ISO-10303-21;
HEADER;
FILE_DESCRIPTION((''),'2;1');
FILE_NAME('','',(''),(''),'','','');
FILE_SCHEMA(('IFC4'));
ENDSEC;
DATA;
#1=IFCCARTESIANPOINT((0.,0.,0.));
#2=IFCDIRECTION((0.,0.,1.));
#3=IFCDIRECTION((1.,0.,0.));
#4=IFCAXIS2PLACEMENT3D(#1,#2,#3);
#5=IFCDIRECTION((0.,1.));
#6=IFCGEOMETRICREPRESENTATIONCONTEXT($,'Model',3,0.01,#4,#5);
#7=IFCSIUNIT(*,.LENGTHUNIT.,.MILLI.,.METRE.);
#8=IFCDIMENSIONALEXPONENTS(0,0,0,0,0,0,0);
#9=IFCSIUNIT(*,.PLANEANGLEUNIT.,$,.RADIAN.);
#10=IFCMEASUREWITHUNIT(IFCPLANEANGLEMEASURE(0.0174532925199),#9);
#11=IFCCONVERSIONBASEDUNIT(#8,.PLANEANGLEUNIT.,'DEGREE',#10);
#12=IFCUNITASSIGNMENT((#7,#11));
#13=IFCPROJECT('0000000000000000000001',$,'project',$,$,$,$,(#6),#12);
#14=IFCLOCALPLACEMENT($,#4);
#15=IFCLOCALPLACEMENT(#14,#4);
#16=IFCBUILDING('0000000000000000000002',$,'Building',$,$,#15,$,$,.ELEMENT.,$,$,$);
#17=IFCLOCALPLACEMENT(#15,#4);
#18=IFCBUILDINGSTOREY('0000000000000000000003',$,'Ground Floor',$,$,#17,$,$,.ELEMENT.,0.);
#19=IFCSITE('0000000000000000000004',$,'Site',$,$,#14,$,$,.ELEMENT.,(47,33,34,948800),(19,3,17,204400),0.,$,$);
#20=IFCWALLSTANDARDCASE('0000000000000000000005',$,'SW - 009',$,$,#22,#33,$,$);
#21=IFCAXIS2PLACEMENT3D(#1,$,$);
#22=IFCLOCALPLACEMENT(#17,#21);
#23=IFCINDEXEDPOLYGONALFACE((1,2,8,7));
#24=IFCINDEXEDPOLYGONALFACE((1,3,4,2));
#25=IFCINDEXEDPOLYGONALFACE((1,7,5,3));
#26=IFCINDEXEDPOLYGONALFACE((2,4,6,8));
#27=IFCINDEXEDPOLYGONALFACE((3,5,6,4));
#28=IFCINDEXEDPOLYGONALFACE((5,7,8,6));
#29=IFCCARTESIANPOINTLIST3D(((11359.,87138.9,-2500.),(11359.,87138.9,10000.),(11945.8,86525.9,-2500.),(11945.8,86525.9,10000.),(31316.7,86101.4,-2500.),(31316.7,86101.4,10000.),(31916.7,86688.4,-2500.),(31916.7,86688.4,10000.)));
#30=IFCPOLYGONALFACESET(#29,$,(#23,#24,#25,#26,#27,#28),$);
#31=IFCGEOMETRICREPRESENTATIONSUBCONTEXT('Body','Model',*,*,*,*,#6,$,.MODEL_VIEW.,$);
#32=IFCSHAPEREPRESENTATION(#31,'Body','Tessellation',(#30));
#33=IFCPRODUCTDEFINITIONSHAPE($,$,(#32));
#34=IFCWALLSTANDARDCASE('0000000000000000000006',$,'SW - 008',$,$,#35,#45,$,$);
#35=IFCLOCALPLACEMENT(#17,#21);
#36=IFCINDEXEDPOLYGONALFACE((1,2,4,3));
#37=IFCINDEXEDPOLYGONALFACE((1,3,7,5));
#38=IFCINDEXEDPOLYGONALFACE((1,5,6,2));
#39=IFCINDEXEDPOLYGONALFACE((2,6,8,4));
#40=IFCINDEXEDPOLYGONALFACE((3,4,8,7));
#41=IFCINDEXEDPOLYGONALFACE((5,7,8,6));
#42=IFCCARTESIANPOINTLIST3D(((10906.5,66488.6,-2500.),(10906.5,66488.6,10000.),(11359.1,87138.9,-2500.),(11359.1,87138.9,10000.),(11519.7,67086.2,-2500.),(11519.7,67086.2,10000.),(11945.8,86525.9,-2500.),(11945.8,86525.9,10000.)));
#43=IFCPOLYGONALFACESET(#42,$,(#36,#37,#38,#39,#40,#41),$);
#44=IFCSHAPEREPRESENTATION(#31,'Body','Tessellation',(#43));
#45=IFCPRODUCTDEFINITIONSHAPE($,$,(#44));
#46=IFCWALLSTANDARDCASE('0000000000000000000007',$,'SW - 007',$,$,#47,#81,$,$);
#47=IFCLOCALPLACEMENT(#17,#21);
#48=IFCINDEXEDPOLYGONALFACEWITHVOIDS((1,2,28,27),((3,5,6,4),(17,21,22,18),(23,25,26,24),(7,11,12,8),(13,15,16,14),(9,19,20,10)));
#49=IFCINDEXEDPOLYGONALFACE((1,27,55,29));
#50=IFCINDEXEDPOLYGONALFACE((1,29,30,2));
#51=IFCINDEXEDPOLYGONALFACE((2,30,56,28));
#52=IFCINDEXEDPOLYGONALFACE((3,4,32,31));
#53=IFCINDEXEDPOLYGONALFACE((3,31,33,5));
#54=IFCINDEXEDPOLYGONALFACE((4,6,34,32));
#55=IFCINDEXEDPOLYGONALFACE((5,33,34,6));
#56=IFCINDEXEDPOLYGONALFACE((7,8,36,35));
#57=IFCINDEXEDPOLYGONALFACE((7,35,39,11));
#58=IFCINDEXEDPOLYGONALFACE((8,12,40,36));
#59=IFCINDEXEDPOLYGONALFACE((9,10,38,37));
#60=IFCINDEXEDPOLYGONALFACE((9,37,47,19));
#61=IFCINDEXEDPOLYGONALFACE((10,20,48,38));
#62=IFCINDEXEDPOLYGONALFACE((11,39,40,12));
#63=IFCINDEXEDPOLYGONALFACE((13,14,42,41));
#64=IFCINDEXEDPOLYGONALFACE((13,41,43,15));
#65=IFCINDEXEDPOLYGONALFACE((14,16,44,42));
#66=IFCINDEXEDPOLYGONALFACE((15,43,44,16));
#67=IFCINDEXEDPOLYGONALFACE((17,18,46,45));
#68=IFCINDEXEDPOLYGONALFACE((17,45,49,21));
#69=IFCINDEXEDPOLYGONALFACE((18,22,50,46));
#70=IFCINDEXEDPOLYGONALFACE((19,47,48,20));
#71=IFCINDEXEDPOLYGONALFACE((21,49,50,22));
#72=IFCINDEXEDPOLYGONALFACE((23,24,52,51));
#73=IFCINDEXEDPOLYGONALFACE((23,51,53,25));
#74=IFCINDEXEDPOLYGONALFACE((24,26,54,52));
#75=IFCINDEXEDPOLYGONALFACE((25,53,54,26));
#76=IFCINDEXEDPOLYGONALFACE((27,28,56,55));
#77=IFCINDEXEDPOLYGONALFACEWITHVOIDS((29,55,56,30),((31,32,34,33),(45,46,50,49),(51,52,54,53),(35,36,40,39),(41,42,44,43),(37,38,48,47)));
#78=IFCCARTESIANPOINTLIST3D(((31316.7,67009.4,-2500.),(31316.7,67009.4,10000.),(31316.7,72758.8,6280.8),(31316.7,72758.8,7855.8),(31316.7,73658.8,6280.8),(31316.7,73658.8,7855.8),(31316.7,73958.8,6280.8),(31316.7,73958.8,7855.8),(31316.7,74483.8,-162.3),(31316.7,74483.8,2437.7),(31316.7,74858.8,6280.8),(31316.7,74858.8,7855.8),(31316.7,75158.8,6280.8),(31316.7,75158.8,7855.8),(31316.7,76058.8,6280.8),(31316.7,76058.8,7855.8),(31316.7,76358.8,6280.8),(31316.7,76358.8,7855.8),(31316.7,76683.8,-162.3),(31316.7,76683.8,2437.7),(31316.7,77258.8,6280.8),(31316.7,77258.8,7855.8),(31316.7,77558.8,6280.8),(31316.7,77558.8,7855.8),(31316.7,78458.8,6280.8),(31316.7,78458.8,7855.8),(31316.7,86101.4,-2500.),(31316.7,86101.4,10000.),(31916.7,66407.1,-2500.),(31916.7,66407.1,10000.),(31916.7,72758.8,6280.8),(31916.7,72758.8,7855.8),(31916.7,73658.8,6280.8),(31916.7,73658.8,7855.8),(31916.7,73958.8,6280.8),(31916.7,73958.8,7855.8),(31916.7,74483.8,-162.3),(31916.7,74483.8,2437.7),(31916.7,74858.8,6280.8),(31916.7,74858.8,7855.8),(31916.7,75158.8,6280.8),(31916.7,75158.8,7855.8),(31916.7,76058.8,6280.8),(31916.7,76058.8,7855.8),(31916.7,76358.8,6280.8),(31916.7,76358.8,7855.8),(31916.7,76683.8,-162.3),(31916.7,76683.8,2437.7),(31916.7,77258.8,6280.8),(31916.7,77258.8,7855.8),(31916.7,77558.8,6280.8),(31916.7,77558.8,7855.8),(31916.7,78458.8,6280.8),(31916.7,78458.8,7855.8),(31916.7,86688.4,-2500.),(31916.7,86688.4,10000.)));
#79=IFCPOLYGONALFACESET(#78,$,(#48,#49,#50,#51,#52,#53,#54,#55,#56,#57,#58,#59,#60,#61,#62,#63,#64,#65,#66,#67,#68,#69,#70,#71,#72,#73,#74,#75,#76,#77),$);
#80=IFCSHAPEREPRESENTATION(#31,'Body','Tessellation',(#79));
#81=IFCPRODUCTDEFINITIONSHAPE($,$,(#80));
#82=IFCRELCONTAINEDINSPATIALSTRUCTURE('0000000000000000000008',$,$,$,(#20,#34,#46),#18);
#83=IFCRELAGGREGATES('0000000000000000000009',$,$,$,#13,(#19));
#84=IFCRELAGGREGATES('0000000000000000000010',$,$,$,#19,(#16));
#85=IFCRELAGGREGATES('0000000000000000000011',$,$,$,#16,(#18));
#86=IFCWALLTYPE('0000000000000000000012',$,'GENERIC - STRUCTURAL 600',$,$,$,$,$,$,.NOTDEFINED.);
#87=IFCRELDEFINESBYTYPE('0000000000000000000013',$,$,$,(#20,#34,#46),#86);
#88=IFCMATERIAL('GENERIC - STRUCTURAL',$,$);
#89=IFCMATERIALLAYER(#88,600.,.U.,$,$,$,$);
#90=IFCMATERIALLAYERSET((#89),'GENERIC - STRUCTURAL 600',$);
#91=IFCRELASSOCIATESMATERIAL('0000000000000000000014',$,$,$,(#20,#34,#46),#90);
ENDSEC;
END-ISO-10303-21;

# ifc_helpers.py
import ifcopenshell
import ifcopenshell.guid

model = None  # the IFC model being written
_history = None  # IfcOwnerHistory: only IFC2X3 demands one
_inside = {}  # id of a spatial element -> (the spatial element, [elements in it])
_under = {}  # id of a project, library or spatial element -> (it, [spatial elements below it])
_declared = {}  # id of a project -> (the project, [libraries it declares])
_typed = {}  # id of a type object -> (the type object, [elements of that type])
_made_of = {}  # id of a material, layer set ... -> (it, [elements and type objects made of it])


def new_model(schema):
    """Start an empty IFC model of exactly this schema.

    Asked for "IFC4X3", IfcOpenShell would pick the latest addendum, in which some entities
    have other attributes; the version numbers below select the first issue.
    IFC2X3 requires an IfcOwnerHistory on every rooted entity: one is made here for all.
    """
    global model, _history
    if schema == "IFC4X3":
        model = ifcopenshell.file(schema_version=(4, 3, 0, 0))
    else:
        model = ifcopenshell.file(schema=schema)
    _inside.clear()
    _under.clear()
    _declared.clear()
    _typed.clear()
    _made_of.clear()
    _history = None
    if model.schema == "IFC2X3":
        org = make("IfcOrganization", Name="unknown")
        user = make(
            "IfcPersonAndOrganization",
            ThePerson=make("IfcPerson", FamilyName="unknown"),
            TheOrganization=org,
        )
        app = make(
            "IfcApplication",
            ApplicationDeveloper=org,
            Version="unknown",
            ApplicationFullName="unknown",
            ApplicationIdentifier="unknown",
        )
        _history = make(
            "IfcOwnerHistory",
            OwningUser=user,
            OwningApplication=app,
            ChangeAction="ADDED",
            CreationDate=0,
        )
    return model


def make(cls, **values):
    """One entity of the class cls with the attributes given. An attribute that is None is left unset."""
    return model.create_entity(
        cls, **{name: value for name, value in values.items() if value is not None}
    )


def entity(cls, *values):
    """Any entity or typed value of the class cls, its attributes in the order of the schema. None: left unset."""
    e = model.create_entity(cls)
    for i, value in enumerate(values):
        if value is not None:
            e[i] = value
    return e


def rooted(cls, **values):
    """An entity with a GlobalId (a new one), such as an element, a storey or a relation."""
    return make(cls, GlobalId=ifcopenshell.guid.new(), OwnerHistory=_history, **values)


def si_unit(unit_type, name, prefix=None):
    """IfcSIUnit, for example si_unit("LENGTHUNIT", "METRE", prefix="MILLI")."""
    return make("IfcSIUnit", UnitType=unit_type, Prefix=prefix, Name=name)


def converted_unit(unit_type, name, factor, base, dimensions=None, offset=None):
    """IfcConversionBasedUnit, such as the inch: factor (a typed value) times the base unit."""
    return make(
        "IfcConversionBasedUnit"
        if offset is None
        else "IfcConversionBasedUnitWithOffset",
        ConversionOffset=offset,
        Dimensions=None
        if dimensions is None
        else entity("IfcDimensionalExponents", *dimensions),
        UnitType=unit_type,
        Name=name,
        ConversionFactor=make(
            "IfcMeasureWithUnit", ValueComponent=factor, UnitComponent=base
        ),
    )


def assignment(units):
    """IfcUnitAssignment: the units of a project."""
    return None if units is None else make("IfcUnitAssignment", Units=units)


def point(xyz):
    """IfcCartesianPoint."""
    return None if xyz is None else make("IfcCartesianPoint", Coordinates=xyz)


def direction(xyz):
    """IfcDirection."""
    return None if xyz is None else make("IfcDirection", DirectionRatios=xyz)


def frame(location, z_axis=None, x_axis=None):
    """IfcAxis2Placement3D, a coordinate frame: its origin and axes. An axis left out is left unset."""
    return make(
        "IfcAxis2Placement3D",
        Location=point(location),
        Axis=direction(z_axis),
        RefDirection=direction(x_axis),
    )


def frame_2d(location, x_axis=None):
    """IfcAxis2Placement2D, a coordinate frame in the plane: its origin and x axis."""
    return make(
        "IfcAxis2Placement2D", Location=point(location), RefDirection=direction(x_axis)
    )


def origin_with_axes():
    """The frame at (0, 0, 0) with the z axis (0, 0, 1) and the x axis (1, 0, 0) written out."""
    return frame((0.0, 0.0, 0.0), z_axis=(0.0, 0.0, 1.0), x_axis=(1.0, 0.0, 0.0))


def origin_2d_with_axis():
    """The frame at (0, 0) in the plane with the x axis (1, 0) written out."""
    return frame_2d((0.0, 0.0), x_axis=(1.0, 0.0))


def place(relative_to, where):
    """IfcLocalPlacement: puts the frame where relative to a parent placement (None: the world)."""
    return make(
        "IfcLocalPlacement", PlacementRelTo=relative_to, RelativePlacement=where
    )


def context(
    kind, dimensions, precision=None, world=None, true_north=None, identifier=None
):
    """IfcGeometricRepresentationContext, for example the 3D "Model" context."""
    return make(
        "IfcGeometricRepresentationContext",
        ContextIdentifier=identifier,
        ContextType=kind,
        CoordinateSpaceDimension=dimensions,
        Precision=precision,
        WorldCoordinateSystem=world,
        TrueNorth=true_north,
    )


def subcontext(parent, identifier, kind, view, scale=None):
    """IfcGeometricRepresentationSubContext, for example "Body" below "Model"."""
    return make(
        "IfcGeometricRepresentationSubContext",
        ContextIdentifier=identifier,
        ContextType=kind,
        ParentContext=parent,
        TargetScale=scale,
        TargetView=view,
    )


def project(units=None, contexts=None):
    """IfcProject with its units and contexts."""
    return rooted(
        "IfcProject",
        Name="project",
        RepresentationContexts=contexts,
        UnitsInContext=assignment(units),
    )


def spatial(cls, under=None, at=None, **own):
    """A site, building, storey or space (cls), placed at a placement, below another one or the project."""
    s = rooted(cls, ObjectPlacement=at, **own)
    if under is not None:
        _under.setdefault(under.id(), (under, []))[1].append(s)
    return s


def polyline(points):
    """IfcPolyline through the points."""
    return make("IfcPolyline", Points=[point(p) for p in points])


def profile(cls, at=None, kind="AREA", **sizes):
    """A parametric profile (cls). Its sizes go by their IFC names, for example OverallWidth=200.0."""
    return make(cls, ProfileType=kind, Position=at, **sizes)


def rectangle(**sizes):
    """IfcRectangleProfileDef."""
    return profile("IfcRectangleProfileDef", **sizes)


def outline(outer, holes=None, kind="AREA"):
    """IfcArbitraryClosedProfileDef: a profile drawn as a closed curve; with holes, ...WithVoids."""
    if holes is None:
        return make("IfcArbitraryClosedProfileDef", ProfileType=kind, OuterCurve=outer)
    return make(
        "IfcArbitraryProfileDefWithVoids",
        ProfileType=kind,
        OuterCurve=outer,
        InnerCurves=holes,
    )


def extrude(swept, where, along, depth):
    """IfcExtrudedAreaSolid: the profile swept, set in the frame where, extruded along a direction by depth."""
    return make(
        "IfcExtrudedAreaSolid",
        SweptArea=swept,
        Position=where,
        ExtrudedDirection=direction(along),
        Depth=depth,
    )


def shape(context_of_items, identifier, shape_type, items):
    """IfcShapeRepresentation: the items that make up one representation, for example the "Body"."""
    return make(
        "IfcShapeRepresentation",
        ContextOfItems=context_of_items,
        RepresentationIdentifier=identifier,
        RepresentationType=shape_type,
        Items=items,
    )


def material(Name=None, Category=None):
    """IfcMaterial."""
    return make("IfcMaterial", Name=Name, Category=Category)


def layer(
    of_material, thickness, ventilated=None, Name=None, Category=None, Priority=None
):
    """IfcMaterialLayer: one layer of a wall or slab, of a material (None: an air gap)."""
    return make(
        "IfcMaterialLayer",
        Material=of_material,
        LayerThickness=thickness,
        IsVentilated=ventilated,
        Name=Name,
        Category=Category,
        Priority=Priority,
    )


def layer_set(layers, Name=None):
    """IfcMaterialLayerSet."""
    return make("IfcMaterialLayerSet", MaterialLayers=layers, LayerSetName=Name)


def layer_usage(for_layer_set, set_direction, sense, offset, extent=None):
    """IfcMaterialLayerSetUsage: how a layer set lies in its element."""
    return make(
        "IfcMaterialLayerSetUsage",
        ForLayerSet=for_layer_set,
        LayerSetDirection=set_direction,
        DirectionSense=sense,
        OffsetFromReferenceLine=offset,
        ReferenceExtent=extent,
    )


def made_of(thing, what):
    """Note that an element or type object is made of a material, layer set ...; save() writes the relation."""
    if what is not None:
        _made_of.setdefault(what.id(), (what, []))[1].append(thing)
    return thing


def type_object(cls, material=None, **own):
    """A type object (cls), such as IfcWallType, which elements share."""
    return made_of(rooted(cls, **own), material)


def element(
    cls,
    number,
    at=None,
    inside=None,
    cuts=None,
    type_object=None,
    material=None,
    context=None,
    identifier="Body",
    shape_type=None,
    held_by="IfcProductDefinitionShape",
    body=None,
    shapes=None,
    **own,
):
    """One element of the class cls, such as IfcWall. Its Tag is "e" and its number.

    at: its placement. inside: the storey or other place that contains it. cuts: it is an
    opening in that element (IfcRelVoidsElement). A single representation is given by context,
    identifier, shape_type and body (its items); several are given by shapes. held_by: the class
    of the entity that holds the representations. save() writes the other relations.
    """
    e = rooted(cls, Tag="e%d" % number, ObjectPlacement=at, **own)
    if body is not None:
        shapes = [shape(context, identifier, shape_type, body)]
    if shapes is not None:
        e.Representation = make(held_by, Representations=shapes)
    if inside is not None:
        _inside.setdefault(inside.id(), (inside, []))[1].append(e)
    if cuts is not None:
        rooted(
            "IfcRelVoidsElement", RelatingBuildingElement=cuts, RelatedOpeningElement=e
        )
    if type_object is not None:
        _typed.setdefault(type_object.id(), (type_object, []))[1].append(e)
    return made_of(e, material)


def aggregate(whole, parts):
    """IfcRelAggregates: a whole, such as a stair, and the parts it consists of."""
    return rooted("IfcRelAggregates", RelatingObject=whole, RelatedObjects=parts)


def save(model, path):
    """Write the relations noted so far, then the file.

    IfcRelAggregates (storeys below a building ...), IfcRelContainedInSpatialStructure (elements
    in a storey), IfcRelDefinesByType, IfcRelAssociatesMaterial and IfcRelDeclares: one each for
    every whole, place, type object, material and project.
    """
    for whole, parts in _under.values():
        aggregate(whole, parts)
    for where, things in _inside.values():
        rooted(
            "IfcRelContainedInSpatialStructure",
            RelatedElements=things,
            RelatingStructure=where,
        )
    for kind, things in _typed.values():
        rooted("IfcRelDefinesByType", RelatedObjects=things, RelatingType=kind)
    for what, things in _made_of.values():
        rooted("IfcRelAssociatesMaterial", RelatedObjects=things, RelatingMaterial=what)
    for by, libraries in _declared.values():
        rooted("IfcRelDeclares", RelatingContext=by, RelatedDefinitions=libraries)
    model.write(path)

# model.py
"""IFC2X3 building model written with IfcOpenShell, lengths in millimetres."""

from ifc_helpers import new_model, entity, si_unit, converted_unit, direction, frame, origin_with_axes, origin_2d_with_axis, place, context, subcontext, project, spatial, polyline, rectangle, outline, extrude, material, layer, layer_set, layer_usage, type_object, element, save


model = new_model("IFC2X3")

# Units and contexts
model_context = context("Model", 3, precision=0.01, world=origin_with_axes(), true_north=direction((0.0, 1.0)))
body_context = subcontext(model_context, "Body", "Model", "MODEL_VIEW")
ifc_project = project(units=[si_unit("LENGTHUNIT", "METRE", prefix="MILLI"), converted_unit("PLANEANGLEUNIT", "DEGREE", entity("IfcPlaneAngleMeasure", 0.0174532925199), si_unit("PLANEANGLEUNIT", "RADIAN"), dimensions=[0, 0, 0, 0, 0, 0, 0])], contexts=[model_context])

# Site, building, storey
site_placement = place(None, origin_with_axes())
site = spatial("IfcSite", under=ifc_project, at=site_placement, Name="Site", CompositionType="ELEMENT", RefLatitude=(47, 33, 34, 948800), RefLongitude=(19, 3, 17, 204400), RefElevation=0.0)
building_placement = place(site_placement, origin_with_axes())
building = spatial("IfcBuilding", under=site, at=building_placement, Name="Building", CompositionType="ELEMENT")
storey_placement = place(building_placement, origin_with_axes())
storey = spatial("IfcBuildingStorey", under=building, at=storey_placement, Name="Ground Floor", CompositionType="ELEMENT", Elevation=0.0)

# Walls
ifc_material = material(Name="GENERIC - STRUCTURAL")
ifc_layer = layer(ifc_material, 600.0, ventilated="UNKNOWN")
ifc_layer_set = layer_set([ifc_layer], Name="GENERIC - STRUCTURAL 600")
ifc_layer_usage_1 = layer_usage(ifc_layer_set, "AXIS2", "NEGATIVE", 0.0)
wall_type = type_object("IfcWallType", Name="GENERIC - STRUCTURAL 600", PredefinedType="NOTDEFINED")
wall_1_placement = place(storey_placement, frame((11359.0, 87138.9, -2500.0), z_axis=(0.0, 0.0, 1.0), x_axis=(0.99976, -0.021911, 0.0)))
element("IfcWallStandardCase", 1, at=wall_1_placement, inside=storey, type_object=wall_type, material=ifc_layer_usage_1, Name="SW - 009", context=body_context, shape_type="SweptSolid", body=[
    extrude(outline(polyline([(600.0, -600.0), (19975.6, -600.0), (20562.6, 0.0), (0.0, 0.0), (600.0, -600.0)])), origin_with_axes(), (0.0, 0.0, 1.0), 12500.0),
])
wall_2_placement = place(storey_placement, frame((10906.5, 66488.6, -2500.0), z_axis=(0.0, 0.0, 1.0), x_axis=(0.021911, 0.99976, 0.0)))
element("IfcWallStandardCase", 2, at=wall_2_placement, inside=storey, type_object=wall_type, material=ifc_layer_usage_1, Name="SW - 008", context=body_context, shape_type="SweptSolid", body=[
    extrude(outline(polyline([(610.9, -600.0), (20055.3, -600.0), (20655.3, 0.0), (0.0, 0.0), (610.9, -600.0)])), origin_with_axes(), (0.0, 0.0, 1.0), 12500.0),
])

# Wall, openings
ifc_layer_usage_2 = layer_usage(ifc_layer_set, "AXIS2", "POSITIVE", 0.0)
wall_3_placement = place(storey_placement, frame((31916.7, 66407.1, -2500.0), z_axis=(0.0, 0.0, 1.0), x_axis=(0.0, 1.0, 0.0)))
wall_3 = element("IfcWallStandardCase", 3, at=wall_3_placement, inside=storey, type_object=wall_type, material=ifc_layer_usage_2, Name="SW - 007", context=body_context, shape_type="SweptSolid", body=[
    extrude(outline(polyline([(0.0, 0.0), (20281.3, 0.0), (19694.3, 600.0), (602.3, 600.0), (0.0, 0.0)])), origin_with_axes(), (0.0, 0.0, 1.0), 12500.0),
])
placement_1 = place(wall_3_placement, frame((-66407.1, 31916.7, 2500.0), z_axis=(0.0, 0.0, 1.0), x_axis=(0.0, -1.0, 0.0)))
element("IfcOpeningElement", 4, at=placement_1, cuts=wall_3, ObjectType="Empty Opening", context=body_context, shape_type="SweptSolid", body=[
    extrude(rectangle(XDim=900.0, YDim=1575.0, at=origin_2d_with_axis()), frame((32516.7, 78008.8, 7068.3), z_axis=(1.0, 0.0, 0.0), x_axis=(0.0, 1.0, 0.0)), (0.0, 0.0, -1.0), 1800.0),
])
element("IfcOpeningElement", 5, at=placement_1, cuts=wall_3, ObjectType="Empty Opening", context=body_context, shape_type="SweptSolid", body=[
    extrude(rectangle(XDim=900.0, YDim=1575.0, at=origin_2d_with_axis()), frame((32516.7, 76808.8, 7068.3), z_axis=(1.0, 0.0, 0.0), x_axis=(0.0, 1.0, 0.0)), (0.0, 0.0, -1.0), 1800.0),
])
element("IfcOpeningElement", 6, at=placement_1, cuts=wall_3, ObjectType="Empty Opening", context=body_context, shape_type="SweptSolid", body=[
    extrude(rectangle(XDim=900.0, YDim=1575.0, at=origin_2d_with_axis()), frame((32516.7, 75608.8, 7068.3), z_axis=(1.0, 0.0, 0.0), x_axis=(0.0, 1.0, 0.0)), (0.0, 0.0, -1.0), 1800.0),
])
element("IfcOpeningElement", 7, at=placement_1, cuts=wall_3, ObjectType="Empty Opening", context=body_context, shape_type="SweptSolid", body=[
    extrude(rectangle(XDim=900.0, YDim=1575.0, at=origin_2d_with_axis()), frame((32516.7, 74408.8, 7068.3), z_axis=(1.0, 0.0, 0.0), x_axis=(0.0, 1.0, 0.0)), (0.0, 0.0, -1.0), 1800.0),
])
element("IfcOpeningElement", 8, at=placement_1, cuts=wall_3, ObjectType="Empty Opening", context=body_context, shape_type="SweptSolid", body=[
    extrude(rectangle(XDim=900.0, YDim=1575.0, at=origin_2d_with_axis()), frame((32516.7, 73208.8, 7068.3), z_axis=(1.0, 0.0, 0.0), x_axis=(0.0, 1.0, 0.0)), (0.0, 0.0, -1.0), 1800.0),
])
element("IfcOpeningElement", 9, at=placement_1, cuts=wall_3, ObjectType="Empty Opening", context=body_context, shape_type="SweptSolid", body=[
    extrude(rectangle(XDim=2200.0, YDim=2600.0, at=origin_2d_with_axis()), frame((32516.7, 75583.8, 1137.7), z_axis=(1.0, 0.0, 0.0), x_axis=(0.0, 1.0, 0.0)), (0.0, 0.0, -1.0), 1800.0),
])

save(model, "model.ifc")
